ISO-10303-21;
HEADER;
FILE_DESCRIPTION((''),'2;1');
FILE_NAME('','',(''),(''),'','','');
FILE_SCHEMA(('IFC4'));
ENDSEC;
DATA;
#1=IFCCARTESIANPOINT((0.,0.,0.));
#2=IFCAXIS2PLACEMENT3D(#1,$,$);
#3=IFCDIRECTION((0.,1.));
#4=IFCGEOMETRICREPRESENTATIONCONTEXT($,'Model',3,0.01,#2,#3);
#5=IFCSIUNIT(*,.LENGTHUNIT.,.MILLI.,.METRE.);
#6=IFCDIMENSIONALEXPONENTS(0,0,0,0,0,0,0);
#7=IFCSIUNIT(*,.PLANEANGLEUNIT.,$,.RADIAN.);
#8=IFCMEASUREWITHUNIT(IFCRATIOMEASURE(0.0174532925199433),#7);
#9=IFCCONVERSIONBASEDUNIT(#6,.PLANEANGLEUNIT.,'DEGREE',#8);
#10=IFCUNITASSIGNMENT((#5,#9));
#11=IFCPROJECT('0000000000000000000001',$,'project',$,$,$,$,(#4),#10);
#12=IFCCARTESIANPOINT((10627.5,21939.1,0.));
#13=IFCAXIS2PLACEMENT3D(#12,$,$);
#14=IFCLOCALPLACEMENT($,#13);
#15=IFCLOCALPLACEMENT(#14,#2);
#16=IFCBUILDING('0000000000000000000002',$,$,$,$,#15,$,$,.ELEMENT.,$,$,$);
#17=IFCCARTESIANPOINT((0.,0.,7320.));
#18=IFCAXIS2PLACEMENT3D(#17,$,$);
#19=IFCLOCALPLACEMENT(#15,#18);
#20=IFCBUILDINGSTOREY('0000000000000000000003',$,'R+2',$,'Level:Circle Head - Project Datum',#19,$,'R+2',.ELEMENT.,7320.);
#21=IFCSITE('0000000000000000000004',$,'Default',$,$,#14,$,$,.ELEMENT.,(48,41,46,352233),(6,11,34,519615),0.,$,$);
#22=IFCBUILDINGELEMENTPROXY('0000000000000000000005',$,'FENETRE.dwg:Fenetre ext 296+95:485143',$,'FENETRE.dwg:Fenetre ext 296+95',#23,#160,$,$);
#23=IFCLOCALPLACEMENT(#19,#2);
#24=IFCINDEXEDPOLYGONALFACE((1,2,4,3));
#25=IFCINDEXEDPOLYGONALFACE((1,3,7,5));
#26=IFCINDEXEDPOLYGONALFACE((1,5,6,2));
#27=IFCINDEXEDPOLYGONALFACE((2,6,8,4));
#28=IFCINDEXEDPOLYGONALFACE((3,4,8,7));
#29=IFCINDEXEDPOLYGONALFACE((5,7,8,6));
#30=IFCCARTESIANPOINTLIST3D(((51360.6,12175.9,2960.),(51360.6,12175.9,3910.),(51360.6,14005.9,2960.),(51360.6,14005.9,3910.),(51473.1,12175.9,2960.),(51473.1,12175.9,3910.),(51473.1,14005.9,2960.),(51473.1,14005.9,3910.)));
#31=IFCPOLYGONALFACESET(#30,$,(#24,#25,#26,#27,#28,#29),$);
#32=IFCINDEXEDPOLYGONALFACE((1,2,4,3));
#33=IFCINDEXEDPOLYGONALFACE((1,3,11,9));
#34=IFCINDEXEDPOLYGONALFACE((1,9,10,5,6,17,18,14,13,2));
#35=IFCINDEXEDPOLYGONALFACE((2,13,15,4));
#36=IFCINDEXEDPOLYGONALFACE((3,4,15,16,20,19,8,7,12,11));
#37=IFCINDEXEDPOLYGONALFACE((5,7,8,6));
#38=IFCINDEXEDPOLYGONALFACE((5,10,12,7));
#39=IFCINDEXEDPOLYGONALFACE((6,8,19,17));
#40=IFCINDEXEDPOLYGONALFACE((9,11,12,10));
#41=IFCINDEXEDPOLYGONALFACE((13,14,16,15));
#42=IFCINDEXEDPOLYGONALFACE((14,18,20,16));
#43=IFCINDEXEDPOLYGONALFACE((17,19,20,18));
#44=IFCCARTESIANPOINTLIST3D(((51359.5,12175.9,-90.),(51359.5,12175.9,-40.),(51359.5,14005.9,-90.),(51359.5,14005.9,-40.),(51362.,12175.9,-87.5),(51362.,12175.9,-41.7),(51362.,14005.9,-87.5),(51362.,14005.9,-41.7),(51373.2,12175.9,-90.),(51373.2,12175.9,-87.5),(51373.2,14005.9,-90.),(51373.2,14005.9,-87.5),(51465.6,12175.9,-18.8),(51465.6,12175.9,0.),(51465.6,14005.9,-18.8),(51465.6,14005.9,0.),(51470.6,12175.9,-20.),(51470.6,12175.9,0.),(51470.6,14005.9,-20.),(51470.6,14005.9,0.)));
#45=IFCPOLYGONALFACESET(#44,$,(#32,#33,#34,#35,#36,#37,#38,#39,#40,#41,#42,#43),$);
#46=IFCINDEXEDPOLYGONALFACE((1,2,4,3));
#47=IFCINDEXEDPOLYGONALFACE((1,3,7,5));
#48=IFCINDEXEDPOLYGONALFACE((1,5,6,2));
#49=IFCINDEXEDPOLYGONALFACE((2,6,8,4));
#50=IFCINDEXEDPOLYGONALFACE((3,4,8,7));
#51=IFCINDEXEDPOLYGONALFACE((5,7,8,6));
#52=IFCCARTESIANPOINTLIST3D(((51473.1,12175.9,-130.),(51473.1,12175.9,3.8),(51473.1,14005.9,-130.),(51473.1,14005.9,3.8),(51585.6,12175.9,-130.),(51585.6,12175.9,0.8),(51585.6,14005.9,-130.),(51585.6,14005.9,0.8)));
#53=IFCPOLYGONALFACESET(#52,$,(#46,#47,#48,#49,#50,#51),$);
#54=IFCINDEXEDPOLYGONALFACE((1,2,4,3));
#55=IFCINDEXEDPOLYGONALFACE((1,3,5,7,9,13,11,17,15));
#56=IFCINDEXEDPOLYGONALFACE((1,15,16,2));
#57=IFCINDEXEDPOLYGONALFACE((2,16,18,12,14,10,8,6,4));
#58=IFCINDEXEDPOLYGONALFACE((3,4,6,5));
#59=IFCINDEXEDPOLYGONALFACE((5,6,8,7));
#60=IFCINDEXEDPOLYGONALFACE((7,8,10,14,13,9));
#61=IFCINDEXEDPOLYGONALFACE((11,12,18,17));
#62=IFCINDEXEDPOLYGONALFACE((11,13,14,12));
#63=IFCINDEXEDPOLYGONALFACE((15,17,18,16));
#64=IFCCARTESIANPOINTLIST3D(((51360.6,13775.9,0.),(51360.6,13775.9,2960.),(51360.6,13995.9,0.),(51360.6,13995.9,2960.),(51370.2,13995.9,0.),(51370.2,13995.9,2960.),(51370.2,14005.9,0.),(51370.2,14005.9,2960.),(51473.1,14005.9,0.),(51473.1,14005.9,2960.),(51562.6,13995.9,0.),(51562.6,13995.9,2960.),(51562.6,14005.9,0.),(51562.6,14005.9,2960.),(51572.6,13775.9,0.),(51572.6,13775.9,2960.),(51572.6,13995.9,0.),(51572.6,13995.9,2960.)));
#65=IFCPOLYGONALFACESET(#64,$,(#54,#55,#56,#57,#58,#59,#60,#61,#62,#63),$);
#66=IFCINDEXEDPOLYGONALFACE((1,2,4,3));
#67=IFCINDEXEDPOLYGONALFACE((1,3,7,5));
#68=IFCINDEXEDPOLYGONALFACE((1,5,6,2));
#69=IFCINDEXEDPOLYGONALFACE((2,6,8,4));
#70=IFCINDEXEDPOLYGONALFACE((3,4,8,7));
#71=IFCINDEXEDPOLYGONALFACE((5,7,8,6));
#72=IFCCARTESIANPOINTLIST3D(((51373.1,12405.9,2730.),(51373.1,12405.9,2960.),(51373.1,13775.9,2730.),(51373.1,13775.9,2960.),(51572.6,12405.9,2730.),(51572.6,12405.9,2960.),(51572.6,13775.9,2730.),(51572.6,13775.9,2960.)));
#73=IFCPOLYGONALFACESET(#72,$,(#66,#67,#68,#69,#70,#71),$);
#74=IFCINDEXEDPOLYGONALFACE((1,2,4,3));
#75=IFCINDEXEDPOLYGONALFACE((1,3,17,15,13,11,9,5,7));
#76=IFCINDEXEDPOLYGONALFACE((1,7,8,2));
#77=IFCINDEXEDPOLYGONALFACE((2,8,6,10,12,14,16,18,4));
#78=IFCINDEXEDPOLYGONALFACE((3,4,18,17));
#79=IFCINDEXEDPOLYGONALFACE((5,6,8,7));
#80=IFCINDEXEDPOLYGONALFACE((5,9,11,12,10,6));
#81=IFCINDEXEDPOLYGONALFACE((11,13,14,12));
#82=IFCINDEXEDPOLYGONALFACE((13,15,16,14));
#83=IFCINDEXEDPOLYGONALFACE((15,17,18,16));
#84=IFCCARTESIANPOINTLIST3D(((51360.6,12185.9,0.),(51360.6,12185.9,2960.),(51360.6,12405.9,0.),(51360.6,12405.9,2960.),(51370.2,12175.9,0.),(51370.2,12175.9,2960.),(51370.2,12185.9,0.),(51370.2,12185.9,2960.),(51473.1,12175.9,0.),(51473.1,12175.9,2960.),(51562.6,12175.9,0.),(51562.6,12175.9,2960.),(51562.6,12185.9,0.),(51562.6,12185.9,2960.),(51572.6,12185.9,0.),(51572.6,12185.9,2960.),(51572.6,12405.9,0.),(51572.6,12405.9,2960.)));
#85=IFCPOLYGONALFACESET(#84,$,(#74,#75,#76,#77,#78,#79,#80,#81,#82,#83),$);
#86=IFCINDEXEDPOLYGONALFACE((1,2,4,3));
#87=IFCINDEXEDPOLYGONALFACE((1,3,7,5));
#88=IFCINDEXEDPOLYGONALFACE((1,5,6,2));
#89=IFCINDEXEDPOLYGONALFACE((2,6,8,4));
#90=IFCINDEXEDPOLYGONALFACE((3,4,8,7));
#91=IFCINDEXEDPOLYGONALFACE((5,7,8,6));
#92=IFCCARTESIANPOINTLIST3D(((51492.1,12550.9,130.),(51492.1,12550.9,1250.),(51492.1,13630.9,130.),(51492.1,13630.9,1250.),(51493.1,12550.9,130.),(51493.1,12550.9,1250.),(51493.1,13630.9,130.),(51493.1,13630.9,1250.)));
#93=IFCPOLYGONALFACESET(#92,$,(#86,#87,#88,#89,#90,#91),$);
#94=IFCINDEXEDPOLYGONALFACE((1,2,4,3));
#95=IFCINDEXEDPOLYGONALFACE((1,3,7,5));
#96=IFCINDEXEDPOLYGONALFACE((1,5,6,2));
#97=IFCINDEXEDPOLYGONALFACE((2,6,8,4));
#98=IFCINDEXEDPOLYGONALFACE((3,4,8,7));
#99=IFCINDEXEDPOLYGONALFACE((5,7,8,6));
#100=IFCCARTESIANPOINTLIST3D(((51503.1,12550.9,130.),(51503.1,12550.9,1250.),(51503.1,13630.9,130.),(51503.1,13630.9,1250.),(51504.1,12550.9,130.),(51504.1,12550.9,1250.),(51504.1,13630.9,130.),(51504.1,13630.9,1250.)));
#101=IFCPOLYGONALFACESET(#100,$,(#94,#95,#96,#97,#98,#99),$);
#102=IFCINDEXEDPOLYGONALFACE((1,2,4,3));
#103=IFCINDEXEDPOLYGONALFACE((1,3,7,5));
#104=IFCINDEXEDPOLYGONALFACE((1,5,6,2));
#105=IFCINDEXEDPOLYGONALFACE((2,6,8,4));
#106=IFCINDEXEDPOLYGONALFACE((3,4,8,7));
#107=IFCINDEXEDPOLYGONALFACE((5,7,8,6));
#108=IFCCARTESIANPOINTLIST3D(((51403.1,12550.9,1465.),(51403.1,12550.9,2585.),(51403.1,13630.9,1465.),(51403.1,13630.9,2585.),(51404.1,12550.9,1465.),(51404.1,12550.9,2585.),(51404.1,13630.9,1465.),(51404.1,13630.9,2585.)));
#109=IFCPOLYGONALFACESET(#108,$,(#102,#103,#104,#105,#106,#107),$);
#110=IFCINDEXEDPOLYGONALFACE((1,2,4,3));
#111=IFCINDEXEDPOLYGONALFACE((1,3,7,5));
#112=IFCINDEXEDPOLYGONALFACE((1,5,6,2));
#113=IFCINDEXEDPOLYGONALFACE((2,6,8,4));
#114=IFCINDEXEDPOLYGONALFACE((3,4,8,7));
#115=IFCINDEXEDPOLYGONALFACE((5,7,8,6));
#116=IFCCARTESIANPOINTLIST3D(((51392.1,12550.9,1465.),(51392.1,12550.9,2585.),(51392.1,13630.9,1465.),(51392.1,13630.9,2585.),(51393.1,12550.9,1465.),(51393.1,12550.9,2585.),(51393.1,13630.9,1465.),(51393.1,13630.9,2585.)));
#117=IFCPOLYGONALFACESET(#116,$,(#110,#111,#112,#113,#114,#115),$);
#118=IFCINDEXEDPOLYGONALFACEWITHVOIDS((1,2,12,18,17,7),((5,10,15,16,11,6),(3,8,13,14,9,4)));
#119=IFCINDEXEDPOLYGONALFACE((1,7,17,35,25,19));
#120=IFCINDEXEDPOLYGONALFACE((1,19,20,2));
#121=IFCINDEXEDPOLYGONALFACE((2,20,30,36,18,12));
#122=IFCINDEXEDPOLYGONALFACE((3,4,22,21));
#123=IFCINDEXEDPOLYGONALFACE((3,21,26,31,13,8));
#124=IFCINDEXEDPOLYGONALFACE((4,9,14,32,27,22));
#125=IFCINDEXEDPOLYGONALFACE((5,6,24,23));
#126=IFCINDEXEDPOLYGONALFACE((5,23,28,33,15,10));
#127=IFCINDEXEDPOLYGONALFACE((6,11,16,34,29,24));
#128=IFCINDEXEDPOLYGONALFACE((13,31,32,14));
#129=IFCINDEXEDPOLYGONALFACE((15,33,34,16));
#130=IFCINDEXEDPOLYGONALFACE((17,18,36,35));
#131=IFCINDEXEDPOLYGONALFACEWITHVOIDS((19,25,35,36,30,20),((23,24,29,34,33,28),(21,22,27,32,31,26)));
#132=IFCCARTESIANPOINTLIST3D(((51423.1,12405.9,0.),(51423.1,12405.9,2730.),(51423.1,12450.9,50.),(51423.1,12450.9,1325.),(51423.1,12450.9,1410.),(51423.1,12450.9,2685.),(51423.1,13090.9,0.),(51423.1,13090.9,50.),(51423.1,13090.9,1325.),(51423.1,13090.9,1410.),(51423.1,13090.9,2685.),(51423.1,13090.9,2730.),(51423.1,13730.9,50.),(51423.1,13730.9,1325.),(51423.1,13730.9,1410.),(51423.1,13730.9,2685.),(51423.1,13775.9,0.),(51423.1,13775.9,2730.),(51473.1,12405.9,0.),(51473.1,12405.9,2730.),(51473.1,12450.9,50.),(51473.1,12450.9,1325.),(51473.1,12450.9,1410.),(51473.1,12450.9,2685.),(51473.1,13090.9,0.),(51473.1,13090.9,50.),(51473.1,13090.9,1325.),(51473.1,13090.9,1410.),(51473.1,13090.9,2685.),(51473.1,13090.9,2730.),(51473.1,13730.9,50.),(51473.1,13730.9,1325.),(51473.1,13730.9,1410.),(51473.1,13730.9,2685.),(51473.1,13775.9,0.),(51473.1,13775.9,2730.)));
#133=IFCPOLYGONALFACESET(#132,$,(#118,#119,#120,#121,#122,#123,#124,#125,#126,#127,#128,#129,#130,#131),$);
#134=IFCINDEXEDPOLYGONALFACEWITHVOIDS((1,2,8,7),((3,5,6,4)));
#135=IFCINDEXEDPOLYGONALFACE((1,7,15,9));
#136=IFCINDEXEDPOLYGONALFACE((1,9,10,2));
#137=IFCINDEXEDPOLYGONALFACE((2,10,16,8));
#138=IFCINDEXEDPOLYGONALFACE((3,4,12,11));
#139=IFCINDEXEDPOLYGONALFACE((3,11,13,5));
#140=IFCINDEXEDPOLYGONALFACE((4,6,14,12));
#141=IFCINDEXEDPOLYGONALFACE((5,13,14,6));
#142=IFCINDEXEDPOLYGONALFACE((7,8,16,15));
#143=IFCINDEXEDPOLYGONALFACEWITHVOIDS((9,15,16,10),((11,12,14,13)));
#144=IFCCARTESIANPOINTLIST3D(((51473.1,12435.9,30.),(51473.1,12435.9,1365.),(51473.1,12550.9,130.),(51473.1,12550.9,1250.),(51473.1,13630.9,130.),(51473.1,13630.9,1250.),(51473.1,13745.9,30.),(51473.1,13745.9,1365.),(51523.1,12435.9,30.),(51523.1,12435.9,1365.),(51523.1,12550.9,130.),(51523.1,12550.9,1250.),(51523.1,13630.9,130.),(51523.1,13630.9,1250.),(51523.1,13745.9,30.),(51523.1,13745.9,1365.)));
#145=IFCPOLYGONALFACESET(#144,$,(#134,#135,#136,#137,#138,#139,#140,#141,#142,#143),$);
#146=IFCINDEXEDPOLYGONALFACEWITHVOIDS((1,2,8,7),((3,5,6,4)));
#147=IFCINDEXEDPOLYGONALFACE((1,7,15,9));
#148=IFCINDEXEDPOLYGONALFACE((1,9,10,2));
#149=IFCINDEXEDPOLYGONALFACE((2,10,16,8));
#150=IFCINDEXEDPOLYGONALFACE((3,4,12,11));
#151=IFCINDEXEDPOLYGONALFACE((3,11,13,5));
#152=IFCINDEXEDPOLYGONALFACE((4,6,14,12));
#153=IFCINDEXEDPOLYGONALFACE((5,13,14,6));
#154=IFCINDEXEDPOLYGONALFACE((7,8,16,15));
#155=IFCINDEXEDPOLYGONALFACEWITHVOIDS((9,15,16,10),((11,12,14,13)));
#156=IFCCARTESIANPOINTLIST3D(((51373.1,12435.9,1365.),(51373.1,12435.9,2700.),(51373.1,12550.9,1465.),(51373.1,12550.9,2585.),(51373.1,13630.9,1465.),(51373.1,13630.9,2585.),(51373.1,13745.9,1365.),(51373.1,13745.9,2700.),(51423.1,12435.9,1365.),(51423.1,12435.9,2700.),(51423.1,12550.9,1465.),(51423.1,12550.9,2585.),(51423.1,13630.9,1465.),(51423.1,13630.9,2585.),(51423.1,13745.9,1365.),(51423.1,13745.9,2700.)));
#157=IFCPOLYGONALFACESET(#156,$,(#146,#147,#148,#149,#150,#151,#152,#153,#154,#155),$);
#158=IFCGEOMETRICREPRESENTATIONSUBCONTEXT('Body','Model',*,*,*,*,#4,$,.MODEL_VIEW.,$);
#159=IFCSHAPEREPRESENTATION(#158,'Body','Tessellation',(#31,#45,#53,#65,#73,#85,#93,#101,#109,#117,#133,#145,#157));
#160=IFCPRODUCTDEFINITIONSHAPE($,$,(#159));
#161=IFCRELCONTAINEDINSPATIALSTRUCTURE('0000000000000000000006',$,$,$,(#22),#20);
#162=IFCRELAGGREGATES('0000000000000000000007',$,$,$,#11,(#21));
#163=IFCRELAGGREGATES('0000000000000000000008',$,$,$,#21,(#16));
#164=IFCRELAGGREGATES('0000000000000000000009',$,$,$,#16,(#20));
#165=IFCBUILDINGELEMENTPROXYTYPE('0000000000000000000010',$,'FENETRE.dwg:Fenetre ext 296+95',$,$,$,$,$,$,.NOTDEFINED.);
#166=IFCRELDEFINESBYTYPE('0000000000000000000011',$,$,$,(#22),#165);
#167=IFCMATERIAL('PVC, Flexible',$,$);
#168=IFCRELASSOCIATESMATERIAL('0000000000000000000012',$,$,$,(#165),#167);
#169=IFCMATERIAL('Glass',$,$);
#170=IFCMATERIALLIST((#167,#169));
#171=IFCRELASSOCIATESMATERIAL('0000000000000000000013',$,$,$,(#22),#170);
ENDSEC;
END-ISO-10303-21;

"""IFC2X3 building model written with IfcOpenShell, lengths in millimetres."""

from ifc_helpers import new_model, entity, si_unit, converted_unit, direction, frame, frame_2d, origin, origin_2d_with_axis, place, context, subcontext, project, spatial, polyline, rectangle, outline, extrude, source, transform, mapped, material, material_list, type_object, type_shapes, element, save


model = new_model("IFC2X3")

# Units and contexts
model_context = context("Model", 3, precision=0.01, world=origin(), true_north=direction((0.0, 1.0)))
body_context = subcontext(model_context, "Body", "Model", "MODEL_VIEW")
ifc_project = project(units=[si_unit("LENGTHUNIT", "METRE", prefix="MILLI"), converted_unit("PLANEANGLEUNIT", "DEGREE", entity("IfcRatioMeasure", 0.0174532925199433), si_unit("PLANEANGLEUNIT", "RADIAN"), dimensions=[0, 0, 0, 0, 0, 0, 0])], contexts=[model_context])

# Site, building, storey
site_placement = place(None, frame((10627.5, 21939.1, 0.0)))
site = spatial("IfcSite", under=ifc_project, at=site_placement, Name="Default", CompositionType="ELEMENT", RefLatitude=(48, 41, 46, 352233), RefLongitude=(6, 11, 34, 519615), RefElevation=0.0)
building_placement = place(site_placement, origin())
building = spatial("IfcBuilding", under=site, at=building_placement, CompositionType="ELEMENT")
storey_placement = place(building_placement, frame((0.0, 0.0, 7320.0)))
storey = spatial("IfcBuildingStorey", under=building, at=storey_placement, Name="R+2", ObjectType="Level:Circle Head - Project Datum", LongName="R+2", CompositionType="ELEMENT", Elevation=7320.0)

# Building element proxy
ifc_material_1 = material(Name="PVC, Flexible")
ifc_material_2 = material(Name="Glass")
building_element_proxy_type_1 = type_object("IfcBuildingElementProxyType", Name="FENETRE.dwg:Fenetre ext 296+95", PredefinedType="NOTDEFINED", material=ifc_material_1)
shared_shape_1 = source(origin(), body_context, "Body", "SweptSolid", [
    extrude(rectangle(XDim=1830.0, YDim=112.5, at=origin_2d_with_axis()), frame((-10.4, 56.3, 2960.0), z_axis=(0.0, 0.0, 1.0), x_axis=(-1.0, 0.0, 0.0)), (0.0, 0.0, 1.0), 950.0),
    extrude(outline(polyline([(-68.6, -14.4), (-72.5, -34.0), (-67.6, -35.0), (-63.9, -16.6), (44.3, -16.6), (54.1, 32.5), (40.6, 35.2), (40.1, 32.7), (51.2, 30.5), (42.2, -14.4), (-68.6, -14.4)])), frame((-925.4, 66.9, -47.5), z_axis=(-1.0, 0.0, 0.0), x_axis=(0.0, 0.980599, -0.196027)), (0.0, 0.0, -1.0), 1830.0),
    extrude(outline(polyline([(-64.7, -56.3), (66.2, -56.3), (66.2, 56.3), (-67.7, 56.3), (-64.7, -56.3)])), frame((-925.4, -56.3, -63.8), z_axis=(1.0, 0.0, 0.0), x_axis=(0.0, 0.0, -1.0)), (0.0, 0.0, 1.0), 1830.0),
    extrude(outline(polyline([(-55.6, 97.0), (-55.6, -5.9), (-55.6, -95.4), (-45.6, -95.4), (-45.6, -105.4), (174.4, -105.4), (174.4, 106.6), (-45.6, 106.6), (-45.6, 97.0), (-55.6, 97.0)])), frame((849.0, 5.9, 0.0), z_axis=(0.0, 0.0, -1.0), x_axis=(-1.0, 0.0, 0.0)), (0.0, 0.0, -1.0), 2960.0),
    extrude(rectangle(XDim=199.5, YDim=1370.0, at=origin_2d_with_axis()), frame((-10.4, 0.3, 2730.0), z_axis=(0.0, 0.0, 1.0), x_axis=(0.0, 1.0, 0.0)), (0.0, 0.0, 1.0), 230.0),
    extrude(outline(polyline([(-97.0, -55.6), (5.9, -55.6), (95.4, -55.6), (95.4, -45.6), (105.4, -45.6), (105.4, 174.4), (-106.6, 174.4), (-106.6, -45.6), (-97.0, -45.6), (-97.0, -55.6)])), frame((-869.9, 5.9, 0.0), z_axis=(0.0, 0.0, 1.0), x_axis=(0.0, -1.0, 0.0)), (0.0, 0.0, 1.0), 2960.0),
    extrude(rectangle(XDim=1.0, YDim=1080.0, at=origin_2d_with_axis()), frame((-10.4, -19.5, 130.0), z_axis=(0.0, 0.0, 1.0), x_axis=(0.0, 1.0, 0.0)), (0.0, 0.0, 1.0), 1120.0),
    extrude(rectangle(XDim=1.0, YDim=1080.0, at=frame_2d((0.0, 0.0), x_axis=(1.0, 0.0))), frame((-10.4, -30.5, 130.0), z_axis=(0.0, 0.0, 1.0), x_axis=(0.0, 1.0, 0.0)), (0.0, 0.0, 1.0), 1120.0),
    extrude(rectangle(XDim=1.0, YDim=1080.0, at=frame_2d((0.0, 0.0), x_axis=(1.0, 0.0))), frame((-10.4, 69.5, 1465.0), z_axis=(0.0, 0.0, 1.0), x_axis=(0.0, 1.0, 0.0)), (0.0, 0.0, 1.0), 1120.0),
    extrude(rectangle(XDim=1.0, YDim=1080.0, at=frame_2d((0.0, 0.0), x_axis=(1.0, 0.0))), frame((-10.4, 80.5, 1465.0), z_axis=(0.0, 0.0, 1.0), x_axis=(0.0, 1.0, 0.0)), (0.0, 0.0, 1.0), 1120.0),
    extrude(outline(polyline([(-685.0, -1365.0), (0.0, -1365.0), (685.0, -1365.0), (685.0, 1365.0), (0.0, 1365.0), (-685.0, 1365.0), (-685.0, -1365.0)]), holes=[polyline([(-640.0, -1320.0), (-640.0, -45.0), (0.0, -45.0), (640.0, -45.0), (640.0, -1320.0), (0.0, -1320.0), (-640.0, -1320.0)]), polyline([(-640.0, 40.0), (-640.0, 1315.0), (0.0, 1315.0), (640.0, 1315.0), (640.0, 40.0), (0.0, 40.0), (-640.0, 40.0)])]), frame((-10.4, 0.0, 1365.0), z_axis=(0.0, 1.0, 0.0), x_axis=(1.0, 0.0, 0.0)), (0.0, 0.0, 1.0), 50.0),
    extrude(outline(polyline([(-655.0, -667.5), (655.0, -667.5), (655.0, 667.5), (-655.0, 667.5), (-655.0, -667.5)]), holes=[polyline([(-540.0, 552.5), (540.0, 552.5), (540.0, -567.5), (-540.0, -567.5), (-540.0, 552.5)])]), frame((-10.4, -50.0, 697.5), z_axis=(0.0, 1.0, 0.0), x_axis=(-1.0, 0.0, 0.0)), (0.0, 0.0, 1.0), 50.0),
    extrude(outline(polyline([(-655.0, -667.5), (655.0, -667.5), (655.0, 667.5), (-655.0, 667.5), (-655.0, -667.5)]), holes=[polyline([(-540.0, 552.5), (540.0, 552.5), (540.0, -567.5), (-540.0, -567.5), (-540.0, 552.5)])]), frame((-10.4, 50.0, 2032.5), z_axis=(0.0, 1.0, 0.0), x_axis=(-1.0, 0.0, 0.0)), (0.0, 0.0, 1.0), 50.0),
])
type_shapes(building_element_proxy_type_1, [shared_shape_1])
ifc_material_list_1 = material_list([ifc_material_1, ifc_material_2])
proxy_1_placement = place(storey_placement, frame((51473.1, 13101.3, 0.0), z_axis=(0.0, 0.0, 1.0), x_axis=(0.0, 1.0, 0.0)))
element("IfcBuildingElementProxy", 1, at=proxy_1_placement, inside=storey, type_object=building_element_proxy_type_1, material=ifc_material_list_1, Name="FENETRE.dwg:Fenetre ext 296+95:485143", ObjectType="FENETRE.dwg:Fenetre ext 296+95", context=body_context, shape_type="MappedRepresentation", body=[
    mapped(shared_shape_1, transform((0.0, 0.0, 0.0), scale=1.0)),
])

save(model, "model.ifc")
